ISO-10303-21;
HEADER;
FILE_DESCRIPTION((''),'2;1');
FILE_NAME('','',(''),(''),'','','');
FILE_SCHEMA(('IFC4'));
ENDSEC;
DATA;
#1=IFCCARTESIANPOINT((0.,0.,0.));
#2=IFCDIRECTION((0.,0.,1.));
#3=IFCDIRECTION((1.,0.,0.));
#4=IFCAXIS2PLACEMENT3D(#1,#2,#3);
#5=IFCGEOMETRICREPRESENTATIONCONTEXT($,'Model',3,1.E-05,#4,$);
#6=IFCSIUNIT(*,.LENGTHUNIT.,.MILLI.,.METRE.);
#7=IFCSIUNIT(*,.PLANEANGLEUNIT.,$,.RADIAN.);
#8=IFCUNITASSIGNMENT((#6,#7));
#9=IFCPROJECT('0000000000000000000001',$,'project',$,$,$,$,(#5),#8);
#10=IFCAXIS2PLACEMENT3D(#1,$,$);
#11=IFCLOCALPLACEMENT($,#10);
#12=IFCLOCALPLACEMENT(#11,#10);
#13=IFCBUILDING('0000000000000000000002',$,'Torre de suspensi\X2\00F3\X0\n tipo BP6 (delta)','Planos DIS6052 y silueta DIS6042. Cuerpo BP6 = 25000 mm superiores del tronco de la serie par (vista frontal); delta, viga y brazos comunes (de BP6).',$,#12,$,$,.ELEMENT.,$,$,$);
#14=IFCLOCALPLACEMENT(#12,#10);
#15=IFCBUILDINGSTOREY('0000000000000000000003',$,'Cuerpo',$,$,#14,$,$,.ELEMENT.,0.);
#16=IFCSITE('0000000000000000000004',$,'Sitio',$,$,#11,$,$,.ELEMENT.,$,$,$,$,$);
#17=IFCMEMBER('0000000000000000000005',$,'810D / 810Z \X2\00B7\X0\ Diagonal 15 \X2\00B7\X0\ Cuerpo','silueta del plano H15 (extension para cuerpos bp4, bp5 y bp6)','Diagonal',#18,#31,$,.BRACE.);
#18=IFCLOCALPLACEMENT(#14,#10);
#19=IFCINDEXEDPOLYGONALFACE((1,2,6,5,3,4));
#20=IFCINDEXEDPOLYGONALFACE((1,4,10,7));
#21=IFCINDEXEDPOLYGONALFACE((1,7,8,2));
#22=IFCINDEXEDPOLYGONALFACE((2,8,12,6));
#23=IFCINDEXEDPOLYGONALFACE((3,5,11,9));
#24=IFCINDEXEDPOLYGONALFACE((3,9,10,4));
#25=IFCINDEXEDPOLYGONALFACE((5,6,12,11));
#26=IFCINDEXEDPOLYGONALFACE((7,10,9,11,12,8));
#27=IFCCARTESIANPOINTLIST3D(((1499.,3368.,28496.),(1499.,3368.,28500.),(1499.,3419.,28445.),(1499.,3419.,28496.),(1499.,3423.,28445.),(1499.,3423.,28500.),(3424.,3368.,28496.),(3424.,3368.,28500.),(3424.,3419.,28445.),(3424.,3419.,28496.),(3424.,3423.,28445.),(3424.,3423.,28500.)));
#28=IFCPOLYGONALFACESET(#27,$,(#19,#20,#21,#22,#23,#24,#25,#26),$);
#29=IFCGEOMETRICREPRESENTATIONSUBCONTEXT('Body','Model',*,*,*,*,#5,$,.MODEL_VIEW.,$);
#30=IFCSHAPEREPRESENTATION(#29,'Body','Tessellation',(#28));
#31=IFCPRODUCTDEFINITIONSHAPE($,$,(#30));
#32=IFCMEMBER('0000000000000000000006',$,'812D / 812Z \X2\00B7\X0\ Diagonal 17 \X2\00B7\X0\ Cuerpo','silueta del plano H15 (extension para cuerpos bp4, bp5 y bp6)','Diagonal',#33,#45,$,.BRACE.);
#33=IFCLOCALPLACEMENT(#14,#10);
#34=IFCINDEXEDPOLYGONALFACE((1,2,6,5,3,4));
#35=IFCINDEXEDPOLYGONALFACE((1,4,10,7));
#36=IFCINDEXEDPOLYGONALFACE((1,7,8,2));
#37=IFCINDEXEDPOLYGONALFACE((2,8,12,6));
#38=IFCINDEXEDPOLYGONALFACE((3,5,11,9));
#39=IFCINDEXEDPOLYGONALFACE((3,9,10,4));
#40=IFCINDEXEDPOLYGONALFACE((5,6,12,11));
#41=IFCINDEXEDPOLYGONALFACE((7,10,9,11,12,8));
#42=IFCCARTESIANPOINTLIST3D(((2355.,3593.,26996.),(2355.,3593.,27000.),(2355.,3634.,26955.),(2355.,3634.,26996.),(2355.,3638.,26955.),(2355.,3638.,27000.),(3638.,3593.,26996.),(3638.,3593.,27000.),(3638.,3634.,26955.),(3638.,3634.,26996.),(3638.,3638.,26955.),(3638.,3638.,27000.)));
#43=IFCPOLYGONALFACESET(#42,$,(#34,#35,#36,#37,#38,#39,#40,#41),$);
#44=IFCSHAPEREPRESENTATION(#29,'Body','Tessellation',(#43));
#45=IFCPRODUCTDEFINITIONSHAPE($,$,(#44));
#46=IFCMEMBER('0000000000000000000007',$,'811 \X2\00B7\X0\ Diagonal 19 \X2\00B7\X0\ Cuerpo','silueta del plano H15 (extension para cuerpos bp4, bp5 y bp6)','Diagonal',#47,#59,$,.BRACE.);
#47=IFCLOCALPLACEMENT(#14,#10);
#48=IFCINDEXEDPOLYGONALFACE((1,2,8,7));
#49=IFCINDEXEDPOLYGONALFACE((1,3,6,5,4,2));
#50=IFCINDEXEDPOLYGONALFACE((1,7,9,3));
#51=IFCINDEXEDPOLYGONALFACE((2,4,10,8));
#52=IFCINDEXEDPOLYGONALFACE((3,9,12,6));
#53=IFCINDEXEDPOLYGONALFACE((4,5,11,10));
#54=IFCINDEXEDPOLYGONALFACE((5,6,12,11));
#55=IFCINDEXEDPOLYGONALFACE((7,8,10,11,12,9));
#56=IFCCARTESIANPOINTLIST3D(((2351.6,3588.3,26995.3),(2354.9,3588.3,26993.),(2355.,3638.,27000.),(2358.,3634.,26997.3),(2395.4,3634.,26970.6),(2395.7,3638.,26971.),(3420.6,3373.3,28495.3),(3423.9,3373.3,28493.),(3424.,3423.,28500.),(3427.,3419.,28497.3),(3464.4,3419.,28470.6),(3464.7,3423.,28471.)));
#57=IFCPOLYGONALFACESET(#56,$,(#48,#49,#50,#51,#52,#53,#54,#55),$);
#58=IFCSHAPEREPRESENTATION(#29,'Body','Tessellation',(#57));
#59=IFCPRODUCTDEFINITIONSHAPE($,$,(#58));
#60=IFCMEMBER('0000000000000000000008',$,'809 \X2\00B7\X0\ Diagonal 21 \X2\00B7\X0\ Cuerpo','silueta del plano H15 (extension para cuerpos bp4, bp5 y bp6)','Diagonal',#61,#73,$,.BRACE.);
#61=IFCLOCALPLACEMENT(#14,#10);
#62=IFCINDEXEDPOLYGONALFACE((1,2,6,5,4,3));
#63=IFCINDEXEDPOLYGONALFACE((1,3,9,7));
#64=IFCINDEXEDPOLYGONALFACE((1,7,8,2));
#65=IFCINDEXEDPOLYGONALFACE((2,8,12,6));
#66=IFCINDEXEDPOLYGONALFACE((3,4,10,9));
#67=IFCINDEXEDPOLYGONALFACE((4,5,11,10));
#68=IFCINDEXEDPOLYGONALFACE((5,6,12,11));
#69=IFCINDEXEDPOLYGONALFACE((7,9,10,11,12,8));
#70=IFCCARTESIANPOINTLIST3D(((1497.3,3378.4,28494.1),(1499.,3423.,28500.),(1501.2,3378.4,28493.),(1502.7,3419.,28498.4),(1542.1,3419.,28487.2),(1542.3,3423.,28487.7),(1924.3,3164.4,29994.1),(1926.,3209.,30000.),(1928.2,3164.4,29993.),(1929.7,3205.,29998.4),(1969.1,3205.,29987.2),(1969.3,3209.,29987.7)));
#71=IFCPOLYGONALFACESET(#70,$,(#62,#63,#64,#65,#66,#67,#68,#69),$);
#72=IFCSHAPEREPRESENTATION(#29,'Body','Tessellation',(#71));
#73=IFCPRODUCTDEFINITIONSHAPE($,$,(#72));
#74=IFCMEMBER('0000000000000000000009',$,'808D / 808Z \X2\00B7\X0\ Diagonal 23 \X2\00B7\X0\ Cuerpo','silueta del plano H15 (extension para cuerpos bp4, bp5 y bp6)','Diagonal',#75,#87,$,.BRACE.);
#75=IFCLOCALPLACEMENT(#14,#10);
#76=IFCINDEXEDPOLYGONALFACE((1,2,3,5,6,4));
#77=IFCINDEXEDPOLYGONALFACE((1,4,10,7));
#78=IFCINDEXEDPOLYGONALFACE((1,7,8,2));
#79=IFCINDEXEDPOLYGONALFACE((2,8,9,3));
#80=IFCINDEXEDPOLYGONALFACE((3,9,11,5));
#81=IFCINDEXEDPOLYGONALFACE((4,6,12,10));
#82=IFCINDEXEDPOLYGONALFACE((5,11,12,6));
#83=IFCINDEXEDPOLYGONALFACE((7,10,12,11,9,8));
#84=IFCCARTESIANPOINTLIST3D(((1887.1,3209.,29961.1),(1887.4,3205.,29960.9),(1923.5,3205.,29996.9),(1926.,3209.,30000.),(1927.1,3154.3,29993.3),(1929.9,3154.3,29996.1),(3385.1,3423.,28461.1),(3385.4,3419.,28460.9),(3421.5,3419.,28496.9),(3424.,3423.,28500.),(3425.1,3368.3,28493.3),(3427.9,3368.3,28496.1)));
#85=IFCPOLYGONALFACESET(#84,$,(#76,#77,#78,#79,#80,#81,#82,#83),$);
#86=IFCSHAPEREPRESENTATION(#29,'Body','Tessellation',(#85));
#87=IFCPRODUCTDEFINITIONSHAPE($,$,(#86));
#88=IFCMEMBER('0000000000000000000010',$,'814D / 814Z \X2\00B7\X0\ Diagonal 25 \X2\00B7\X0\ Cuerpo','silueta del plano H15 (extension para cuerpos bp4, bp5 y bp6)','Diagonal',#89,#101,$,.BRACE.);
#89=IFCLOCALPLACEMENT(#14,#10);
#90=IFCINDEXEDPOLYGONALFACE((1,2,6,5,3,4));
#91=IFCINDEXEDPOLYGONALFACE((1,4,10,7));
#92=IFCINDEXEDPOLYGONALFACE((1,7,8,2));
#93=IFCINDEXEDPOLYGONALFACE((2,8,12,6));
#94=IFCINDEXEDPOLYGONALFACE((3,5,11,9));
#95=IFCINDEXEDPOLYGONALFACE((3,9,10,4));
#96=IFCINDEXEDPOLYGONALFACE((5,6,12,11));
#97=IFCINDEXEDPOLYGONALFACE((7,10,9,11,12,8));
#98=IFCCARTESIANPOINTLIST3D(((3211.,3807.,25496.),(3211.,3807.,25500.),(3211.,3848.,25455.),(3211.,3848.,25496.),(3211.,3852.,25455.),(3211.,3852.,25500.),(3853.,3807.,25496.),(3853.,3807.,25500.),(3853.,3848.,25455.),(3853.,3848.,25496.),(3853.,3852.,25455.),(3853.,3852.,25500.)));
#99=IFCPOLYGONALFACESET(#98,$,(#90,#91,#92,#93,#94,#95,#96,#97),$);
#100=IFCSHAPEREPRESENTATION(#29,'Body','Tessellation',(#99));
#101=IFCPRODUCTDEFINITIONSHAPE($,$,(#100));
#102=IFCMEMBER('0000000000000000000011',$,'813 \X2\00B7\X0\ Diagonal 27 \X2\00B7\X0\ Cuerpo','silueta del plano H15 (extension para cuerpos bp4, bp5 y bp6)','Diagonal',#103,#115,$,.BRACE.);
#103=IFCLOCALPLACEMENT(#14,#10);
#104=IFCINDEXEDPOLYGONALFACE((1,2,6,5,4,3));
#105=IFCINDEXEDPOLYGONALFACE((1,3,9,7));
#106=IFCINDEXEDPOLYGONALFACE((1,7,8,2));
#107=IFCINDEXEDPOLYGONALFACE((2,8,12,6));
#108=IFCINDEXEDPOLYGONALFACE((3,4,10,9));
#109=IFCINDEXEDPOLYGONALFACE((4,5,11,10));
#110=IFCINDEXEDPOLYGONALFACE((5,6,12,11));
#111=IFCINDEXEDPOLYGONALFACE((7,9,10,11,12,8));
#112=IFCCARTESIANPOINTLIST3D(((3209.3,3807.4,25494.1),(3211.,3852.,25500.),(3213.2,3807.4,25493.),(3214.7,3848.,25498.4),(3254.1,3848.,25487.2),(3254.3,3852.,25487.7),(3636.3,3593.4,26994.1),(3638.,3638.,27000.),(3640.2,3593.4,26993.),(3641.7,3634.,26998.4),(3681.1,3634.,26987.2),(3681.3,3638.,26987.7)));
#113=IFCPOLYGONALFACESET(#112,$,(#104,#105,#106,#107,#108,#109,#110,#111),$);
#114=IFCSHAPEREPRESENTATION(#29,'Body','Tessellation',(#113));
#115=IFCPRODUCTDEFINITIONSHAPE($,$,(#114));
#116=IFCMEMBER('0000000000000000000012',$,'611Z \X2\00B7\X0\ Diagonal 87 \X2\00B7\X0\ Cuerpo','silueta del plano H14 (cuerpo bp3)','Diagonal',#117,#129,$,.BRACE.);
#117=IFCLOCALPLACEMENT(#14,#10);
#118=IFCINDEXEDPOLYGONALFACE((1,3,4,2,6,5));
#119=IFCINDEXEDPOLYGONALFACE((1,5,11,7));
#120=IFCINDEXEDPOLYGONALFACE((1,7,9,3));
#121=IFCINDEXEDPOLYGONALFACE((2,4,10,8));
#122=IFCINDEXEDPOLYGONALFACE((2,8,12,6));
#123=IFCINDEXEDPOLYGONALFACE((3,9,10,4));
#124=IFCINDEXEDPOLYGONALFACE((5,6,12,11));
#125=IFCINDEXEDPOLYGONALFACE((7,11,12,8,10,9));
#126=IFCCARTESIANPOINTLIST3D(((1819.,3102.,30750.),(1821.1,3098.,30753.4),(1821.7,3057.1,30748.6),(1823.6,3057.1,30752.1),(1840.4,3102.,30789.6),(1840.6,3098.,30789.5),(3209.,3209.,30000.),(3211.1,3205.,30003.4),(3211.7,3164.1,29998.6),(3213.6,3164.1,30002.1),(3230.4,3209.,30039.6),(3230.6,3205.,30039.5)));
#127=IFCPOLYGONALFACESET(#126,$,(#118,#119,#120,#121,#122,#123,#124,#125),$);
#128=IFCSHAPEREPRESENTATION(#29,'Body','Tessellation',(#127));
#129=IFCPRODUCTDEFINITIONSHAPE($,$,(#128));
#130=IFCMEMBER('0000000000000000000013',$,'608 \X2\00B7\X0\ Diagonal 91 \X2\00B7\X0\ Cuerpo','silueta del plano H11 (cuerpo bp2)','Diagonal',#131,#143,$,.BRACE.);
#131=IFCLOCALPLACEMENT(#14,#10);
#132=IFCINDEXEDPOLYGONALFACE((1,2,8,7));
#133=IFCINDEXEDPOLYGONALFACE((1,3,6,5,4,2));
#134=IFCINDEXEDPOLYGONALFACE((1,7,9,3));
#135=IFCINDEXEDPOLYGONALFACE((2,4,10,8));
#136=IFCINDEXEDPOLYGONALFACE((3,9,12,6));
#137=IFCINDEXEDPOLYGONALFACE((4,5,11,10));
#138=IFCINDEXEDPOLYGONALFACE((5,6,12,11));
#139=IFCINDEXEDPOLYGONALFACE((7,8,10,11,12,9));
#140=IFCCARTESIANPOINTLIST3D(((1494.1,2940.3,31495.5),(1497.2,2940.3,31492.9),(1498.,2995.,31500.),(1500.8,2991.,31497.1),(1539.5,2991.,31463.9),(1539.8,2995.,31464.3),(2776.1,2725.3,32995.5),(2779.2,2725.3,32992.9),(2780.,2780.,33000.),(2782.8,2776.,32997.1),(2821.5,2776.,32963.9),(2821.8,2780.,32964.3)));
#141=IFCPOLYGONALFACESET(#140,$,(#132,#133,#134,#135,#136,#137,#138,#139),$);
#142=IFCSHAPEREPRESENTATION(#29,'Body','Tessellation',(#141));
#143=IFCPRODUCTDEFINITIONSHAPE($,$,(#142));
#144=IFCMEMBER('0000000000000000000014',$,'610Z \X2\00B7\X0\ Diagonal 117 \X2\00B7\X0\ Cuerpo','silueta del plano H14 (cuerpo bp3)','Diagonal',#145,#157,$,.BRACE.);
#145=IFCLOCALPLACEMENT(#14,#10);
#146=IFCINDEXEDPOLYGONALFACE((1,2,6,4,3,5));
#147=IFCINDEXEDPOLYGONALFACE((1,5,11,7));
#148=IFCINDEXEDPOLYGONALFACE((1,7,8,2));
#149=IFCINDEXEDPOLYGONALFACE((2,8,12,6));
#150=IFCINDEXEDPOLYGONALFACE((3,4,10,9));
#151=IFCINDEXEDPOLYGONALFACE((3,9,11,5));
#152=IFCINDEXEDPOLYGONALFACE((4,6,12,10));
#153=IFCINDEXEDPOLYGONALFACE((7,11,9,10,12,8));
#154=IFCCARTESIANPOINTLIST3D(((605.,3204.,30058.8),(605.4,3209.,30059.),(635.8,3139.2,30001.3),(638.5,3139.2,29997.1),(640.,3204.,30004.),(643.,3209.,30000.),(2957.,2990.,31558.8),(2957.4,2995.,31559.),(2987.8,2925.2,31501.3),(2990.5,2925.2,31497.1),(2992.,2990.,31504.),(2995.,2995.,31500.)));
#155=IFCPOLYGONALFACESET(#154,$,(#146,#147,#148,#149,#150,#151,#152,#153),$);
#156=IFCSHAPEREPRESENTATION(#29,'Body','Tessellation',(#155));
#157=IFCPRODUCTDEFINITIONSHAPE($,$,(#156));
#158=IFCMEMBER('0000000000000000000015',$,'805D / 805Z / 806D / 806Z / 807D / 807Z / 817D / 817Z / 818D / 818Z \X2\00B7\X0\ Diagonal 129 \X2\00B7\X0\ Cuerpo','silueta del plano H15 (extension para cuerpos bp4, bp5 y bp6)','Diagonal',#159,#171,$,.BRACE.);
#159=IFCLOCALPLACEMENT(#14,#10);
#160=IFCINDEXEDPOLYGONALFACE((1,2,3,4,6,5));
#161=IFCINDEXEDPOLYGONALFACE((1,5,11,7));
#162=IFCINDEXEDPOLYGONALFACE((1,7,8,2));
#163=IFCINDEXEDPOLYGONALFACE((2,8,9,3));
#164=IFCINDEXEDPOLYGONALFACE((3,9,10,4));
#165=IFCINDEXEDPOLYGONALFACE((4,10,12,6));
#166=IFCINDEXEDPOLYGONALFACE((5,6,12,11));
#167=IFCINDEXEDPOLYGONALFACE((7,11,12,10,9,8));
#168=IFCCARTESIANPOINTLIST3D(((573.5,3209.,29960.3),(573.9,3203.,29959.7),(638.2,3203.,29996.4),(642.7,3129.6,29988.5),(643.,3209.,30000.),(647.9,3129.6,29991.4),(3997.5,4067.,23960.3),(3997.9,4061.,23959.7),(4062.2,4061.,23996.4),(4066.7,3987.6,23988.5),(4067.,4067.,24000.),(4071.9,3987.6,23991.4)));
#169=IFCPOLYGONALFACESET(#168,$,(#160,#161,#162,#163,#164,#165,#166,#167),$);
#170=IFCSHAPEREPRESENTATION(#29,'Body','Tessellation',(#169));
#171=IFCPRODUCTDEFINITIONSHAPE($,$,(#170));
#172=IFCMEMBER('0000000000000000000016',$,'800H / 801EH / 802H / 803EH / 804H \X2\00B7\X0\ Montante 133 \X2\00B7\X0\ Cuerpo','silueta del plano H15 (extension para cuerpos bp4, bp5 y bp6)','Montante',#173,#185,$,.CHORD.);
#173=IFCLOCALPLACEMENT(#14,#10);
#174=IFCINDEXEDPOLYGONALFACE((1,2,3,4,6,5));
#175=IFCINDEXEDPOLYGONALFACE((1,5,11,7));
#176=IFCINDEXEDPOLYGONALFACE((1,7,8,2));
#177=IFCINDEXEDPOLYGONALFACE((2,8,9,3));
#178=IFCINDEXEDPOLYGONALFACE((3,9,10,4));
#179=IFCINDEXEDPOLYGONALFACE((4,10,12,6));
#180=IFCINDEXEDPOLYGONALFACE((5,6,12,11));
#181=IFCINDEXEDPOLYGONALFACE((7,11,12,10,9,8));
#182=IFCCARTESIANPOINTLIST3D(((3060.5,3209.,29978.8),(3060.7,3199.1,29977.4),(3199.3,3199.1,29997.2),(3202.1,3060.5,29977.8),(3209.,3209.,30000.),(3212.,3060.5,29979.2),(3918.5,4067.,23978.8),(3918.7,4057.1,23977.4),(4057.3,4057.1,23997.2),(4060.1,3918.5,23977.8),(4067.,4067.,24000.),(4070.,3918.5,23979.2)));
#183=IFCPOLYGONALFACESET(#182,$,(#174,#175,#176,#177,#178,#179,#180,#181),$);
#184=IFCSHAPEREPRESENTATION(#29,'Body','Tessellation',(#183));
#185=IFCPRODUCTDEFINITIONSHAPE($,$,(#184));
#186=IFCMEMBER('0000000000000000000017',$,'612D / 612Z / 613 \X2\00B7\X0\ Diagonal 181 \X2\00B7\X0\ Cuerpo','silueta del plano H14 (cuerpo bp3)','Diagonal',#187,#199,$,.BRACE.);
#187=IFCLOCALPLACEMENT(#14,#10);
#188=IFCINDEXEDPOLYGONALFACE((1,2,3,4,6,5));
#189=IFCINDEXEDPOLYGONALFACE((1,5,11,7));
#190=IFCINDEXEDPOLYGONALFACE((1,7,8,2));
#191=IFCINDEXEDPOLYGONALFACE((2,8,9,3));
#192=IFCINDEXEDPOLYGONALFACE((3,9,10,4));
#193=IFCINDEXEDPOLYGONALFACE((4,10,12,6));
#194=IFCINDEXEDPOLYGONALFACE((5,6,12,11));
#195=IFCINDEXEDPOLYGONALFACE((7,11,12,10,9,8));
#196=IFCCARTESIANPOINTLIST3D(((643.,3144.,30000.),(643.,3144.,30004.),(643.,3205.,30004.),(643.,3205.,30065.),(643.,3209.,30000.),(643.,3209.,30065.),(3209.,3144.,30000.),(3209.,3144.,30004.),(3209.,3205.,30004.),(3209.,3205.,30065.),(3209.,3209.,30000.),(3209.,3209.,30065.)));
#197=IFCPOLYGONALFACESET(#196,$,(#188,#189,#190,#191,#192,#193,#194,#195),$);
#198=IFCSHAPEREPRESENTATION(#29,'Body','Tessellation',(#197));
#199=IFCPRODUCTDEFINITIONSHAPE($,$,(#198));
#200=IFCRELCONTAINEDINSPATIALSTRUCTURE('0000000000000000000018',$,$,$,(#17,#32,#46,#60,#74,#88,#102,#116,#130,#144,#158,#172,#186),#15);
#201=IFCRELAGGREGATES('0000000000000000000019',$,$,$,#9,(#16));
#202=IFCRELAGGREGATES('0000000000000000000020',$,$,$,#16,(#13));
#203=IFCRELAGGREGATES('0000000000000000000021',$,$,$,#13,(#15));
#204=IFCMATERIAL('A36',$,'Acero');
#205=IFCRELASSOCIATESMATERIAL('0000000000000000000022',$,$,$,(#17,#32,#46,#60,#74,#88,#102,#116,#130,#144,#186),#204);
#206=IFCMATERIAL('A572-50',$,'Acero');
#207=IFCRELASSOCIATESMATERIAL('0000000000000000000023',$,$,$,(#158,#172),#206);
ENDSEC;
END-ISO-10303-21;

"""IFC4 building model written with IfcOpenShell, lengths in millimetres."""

from ifc_helpers import new_model, si_unit, frame, frame_2d, origin, origin_with_axes, place, context, subcontext, project, spatial, l_section, extrude, material, element, save


model = new_model("IFC4")

# Units and contexts
model_context = context("Model", 3, precision=1e-05, world=origin_with_axes())
body_context = subcontext(model_context, "Body", "Model", "MODEL_VIEW")
ifc_project = project(units=[si_unit("LENGTHUNIT", "METRE", prefix="MILLI"), si_unit("PLANEANGLEUNIT", "RADIAN")], contexts=[model_context])

# Site, building, storey
site_placement = place(None, origin())
site = spatial("IfcSite", under=ifc_project, at=site_placement, Name="Sitio", CompositionType="ELEMENT")
building_placement = place(site_placement, origin())
building = spatial("IfcBuilding", under=site, at=building_placement, Name="Torre de suspensión tipo BP6 (delta)", Description="Planos DIS6052 y silueta DIS6042. Cuerpo BP6 = 25000 mm superiores del tronco de la serie par (vista frontal); delta, viga y brazos comunes (de BP6).", CompositionType="ELEMENT")
storey_placement = place(building_placement, origin())
storey = spatial("IfcBuildingStorey", under=building, at=storey_placement, Name="Cuerpo", CompositionType="ELEMENT", Elevation=0.0)

# Members
ifc_material_1 = material(Name="A36", Category="Acero")
member_1_placement = place(storey_placement, frame((1499.0, 3423.0, 28500.0), z_axis=(1.0, 0.0, 0.0), x_axis=(0.0, -1.0, 0.0)))
element("IfcMember", 1, at=member_1_placement, inside=storey, material=ifc_material_1, Name="810D / 810Z · Diagonal 15 · Cuerpo", Description="silueta del plano H15 (extension para cuerpos bp4, bp5 y bp6)", ObjectType="Diagonal", PredefinedType="BRACE", context=body_context, shape_type="SweptSolid", body=[
    extrude(l_section(Depth=55.0, Width=55.0, Thickness=4.0, at=frame_2d((27.5, 27.5))), None, (0.0, 0.0, 1.0), 1925.0),
])
member_2_placement = place(storey_placement, frame((2355.0, 3638.0, 27000.0), z_axis=(1.0, 0.0, 0.0), x_axis=(0.0, -1.0, 0.0)))
element("IfcMember", 2, at=member_2_placement, inside=storey, material=ifc_material_1, Name="812D / 812Z · Diagonal 17 · Cuerpo", Description="silueta del plano H15 (extension para cuerpos bp4, bp5 y bp6)", ObjectType="Diagonal", PredefinedType="BRACE", context=body_context, shape_type="SweptSolid", body=[
    extrude(l_section(Depth=45.0, Width=45.0, Thickness=4.0, at=frame_2d((22.5, 22.5))), None, (0.0, 0.0, 1.0), 1283.0),
])
member_3_placement = place(storey_placement, frame((2355.0, 3638.0, 27000.0), z_axis=(0.576451, -0.115937, 0.808865), x_axis=(-0.067286, -0.993257, -0.094414)))
element("IfcMember", 3, at=member_3_placement, inside=storey, material=ifc_material_1, Name="811 · Diagonal 19 · Cuerpo", Description="silueta del plano H15 (extension para cuerpos bp4, bp5 y bp6)", ObjectType="Diagonal", PredefinedType="BRACE", context=body_context, shape_type="SweptSolid", body=[
    extrude(l_section(Depth=50.0, Width=50.0, Thickness=4.0, at=frame_2d((25.0, 25.0))), None, (0.0, 0.0, 1.0), 1854.5),
])
member_4_placement = place(storey_placement, frame((1499.0, 3423.0, 28500.0), z_axis=(0.271248, -0.135942, 0.952861), x_axis=(-0.037219, -0.990717, -0.130747)))
element("IfcMember", 4, at=member_4_placement, inside=storey, material=ifc_material_1, Name="809 · Diagonal 21 · Cuerpo", Description="silueta del plano H15 (extension para cuerpos bp4, bp5 y bp6)", ObjectType="Diagonal", PredefinedType="BRACE", context=body_context, shape_type="SweptSolid", body=[
    extrude(l_section(Depth=45.0, Width=45.0, Thickness=4.0, at=frame_2d((22.5, 22.5))), None, (0.0, 0.0, 1.0), 1574.2),
])
member_5_placement = place(storey_placement, frame((1926.0, 3209.0, 30000.0), z_axis=(0.703062, 0.100437, -0.704), x_axis=(0.070973, -0.994943, -0.071067)))
element("IfcMember", 5, at=member_5_placement, inside=storey, material=ifc_material_1, Name="808D / 808Z · Diagonal 23 · Cuerpo", Description="silueta del plano H15 (extension para cuerpos bp4, bp5 y bp6)", ObjectType="Diagonal", PredefinedType="BRACE", context=body_context, shape_type="SweptSolid", body=[
    extrude(l_section(Depth=55.0, Width=55.0, Thickness=4.0, at=frame_2d((27.5, 27.5))), None, (0.0, 0.0, 1.0), 2130.7),
])
member_6_placement = place(storey_placement, frame((3211.0, 3852.0, 25500.0), z_axis=(1.0, 0.0, 0.0), x_axis=(0.0, -1.0, 0.0)))
element("IfcMember", 6, at=member_6_placement, inside=storey, material=ifc_material_1, Name="814D / 814Z · Diagonal 25 · Cuerpo", Description="silueta del plano H15 (extension para cuerpos bp4, bp5 y bp6)", ObjectType="Diagonal", PredefinedType="BRACE", context=body_context, shape_type="SweptSolid", body=[
    extrude(l_section(Depth=45.0, Width=45.0, Thickness=4.0, at=frame_2d((22.5, 22.5))), None, (0.0, 0.0, 1.0), 642.0),
])
member_7_placement = place(storey_placement, frame((3211.0, 3852.0, 25500.0), z_axis=(0.271248, -0.135942, 0.952861), x_axis=(-0.037219, -0.990717, -0.130747)))
element("IfcMember", 7, at=member_7_placement, inside=storey, material=ifc_material_1, Name="813 · Diagonal 27 · Cuerpo", Description="silueta del plano H15 (extension para cuerpos bp4, bp5 y bp6)", ObjectType="Diagonal", PredefinedType="BRACE", context=body_context, shape_type="SweptSolid", body=[
    extrude(l_section(Depth=45.0, Width=45.0, Thickness=4.0, at=frame_2d((22.5, 22.5))), None, (0.0, 0.0, 1.0), 1574.2),
])
member_8_placement = place(storey_placement, frame((3209.0, 3209.0, 30000.0), z_axis=(-0.878052, -0.067591, 0.473769), x_axis=(0.059484, -0.997713, -0.032096)))
element("IfcMember", 8, at=member_8_placement, inside=storey, material=ifc_material_1, Name="611Z · Diagonal 87 · Cuerpo", Description="silueta del plano H14 (cuerpo bp3)", ObjectType="Diagonal", PredefinedType="BRACE", context=body_context, shape_type="SweptSolid", body=[
    extrude(l_section(Depth=45.0, Width=45.0, Thickness=4.0, at=frame_2d((22.5, 22.5))), None, (0.0, 0.0, 1.0), 1583.1),
])
member_9_placement = place(storey_placement, frame((1498.0, 2995.0, 31500.0), z_axis=(0.645883, -0.108319, 0.755713), x_axis=(-0.070375, -0.994116, -0.082342)))
element("IfcMember", 9, at=member_9_placement, inside=storey, material=ifc_material_1, Name="608 · Diagonal 91 · Cuerpo", Description="silueta del plano H11 (cuerpo bp2)", ObjectType="Diagonal", PredefinedType="BRACE", context=body_context, shape_type="SweptSolid", body=[
    extrude(l_section(Depth=55.0, Width=55.0, Thickness=4.0, at=frame_2d((27.5, 27.5))), None, (0.0, 0.0, 1.0), 1984.9),
])
member_10_placement = place(storey_placement, frame((2995.0, 2995.0, 31500.0), z_axis=(-0.84066, 0.076489, -0.536135), x_axis=(-0.06449, -0.99707, -0.041129)))
element("IfcMember", 10, at=member_10_placement, inside=storey, material=ifc_material_1, Name="610Z · Diagonal 117 · Cuerpo", Description="silueta del plano H14 (cuerpo bp3)", ObjectType="Diagonal", PredefinedType="BRACE", context=body_context, shape_type="SweptSolid", body=[
    extrude(l_section(Depth=70.0, Width=70.0, Thickness=5.0, at=frame_2d((35.0, 35.0))), None, (0.0, 0.0, 1.0), 2797.8),
])
ifc_material_2 = material(Name="A572-50", Category="Acero")
member_11_placement = place(storey_placement, frame((643.0, 3209.0, 30000.0), z_axis=(0.491861, 0.123253, -0.861906), x_axis=(0.061089, -0.992375, -0.107048)))
element("IfcMember", 11, at=member_11_placement, inside=storey, material=ifc_material_2, Name="805D / 805Z / 806D / 806Z / 807D / 807Z / 817D / 817Z / 818D / 818Z · Diagonal 129 · Cuerpo", Description="silueta del plano H15 (extension para cuerpos bp4, bp5 y bp6)", ObjectType="Diagonal", PredefinedType="BRACE", context=body_context, shape_type="SweptSolid", body=[
    extrude(l_section(Depth=80.0, Width=80.0, Thickness=6.0, at=frame_2d((40.0, 40.0))), None, (0.0, 0.0, 1.0), 6961.3),
])
member_12_placement = place(storey_placement, frame((3209.0, 3209.0, 30000.0), z_axis=(0.140163, 0.140163, -0.980158), x_axis=(0.019841, -0.990129, -0.138751)))
element("IfcMember", 12, at=member_12_placement, inside=storey, material=ifc_material_2, Name="800H / 801EH / 802H / 803EH / 804H · Montante 133 · Cuerpo", Description="silueta del plano H15 (extension para cuerpos bp4, bp5 y bp6)", ObjectType="Montante", PredefinedType="CHORD", context=body_context, shape_type="SweptSolid", body=[
    extrude(l_section(Depth=150.0, Width=150.0, Thickness=10.0, at=frame_2d((75.0, 75.0))), None, (0.0, 0.0, 1.0), 6121.5),
])
member_13_placement = place(storey_placement, frame((3209.0, 3209.0, 30000.0), z_axis=(-1.0, 0.0, 0.0), x_axis=(0.0, -1.0, 0.0)))
element("IfcMember", 13, at=member_13_placement, inside=storey, material=ifc_material_1, Name="612D / 612Z / 613 · Diagonal 181 · Cuerpo", Description="silueta del plano H14 (cuerpo bp3)", ObjectType="Diagonal", PredefinedType="BRACE", context=body_context, shape_type="SweptSolid", body=[
    extrude(l_section(Depth=65.0, Width=65.0, Thickness=4.0, at=frame_2d((32.5, 32.5))), None, (0.0, 0.0, 1.0), 2566.0),
])

save(model, "model.ifc")
